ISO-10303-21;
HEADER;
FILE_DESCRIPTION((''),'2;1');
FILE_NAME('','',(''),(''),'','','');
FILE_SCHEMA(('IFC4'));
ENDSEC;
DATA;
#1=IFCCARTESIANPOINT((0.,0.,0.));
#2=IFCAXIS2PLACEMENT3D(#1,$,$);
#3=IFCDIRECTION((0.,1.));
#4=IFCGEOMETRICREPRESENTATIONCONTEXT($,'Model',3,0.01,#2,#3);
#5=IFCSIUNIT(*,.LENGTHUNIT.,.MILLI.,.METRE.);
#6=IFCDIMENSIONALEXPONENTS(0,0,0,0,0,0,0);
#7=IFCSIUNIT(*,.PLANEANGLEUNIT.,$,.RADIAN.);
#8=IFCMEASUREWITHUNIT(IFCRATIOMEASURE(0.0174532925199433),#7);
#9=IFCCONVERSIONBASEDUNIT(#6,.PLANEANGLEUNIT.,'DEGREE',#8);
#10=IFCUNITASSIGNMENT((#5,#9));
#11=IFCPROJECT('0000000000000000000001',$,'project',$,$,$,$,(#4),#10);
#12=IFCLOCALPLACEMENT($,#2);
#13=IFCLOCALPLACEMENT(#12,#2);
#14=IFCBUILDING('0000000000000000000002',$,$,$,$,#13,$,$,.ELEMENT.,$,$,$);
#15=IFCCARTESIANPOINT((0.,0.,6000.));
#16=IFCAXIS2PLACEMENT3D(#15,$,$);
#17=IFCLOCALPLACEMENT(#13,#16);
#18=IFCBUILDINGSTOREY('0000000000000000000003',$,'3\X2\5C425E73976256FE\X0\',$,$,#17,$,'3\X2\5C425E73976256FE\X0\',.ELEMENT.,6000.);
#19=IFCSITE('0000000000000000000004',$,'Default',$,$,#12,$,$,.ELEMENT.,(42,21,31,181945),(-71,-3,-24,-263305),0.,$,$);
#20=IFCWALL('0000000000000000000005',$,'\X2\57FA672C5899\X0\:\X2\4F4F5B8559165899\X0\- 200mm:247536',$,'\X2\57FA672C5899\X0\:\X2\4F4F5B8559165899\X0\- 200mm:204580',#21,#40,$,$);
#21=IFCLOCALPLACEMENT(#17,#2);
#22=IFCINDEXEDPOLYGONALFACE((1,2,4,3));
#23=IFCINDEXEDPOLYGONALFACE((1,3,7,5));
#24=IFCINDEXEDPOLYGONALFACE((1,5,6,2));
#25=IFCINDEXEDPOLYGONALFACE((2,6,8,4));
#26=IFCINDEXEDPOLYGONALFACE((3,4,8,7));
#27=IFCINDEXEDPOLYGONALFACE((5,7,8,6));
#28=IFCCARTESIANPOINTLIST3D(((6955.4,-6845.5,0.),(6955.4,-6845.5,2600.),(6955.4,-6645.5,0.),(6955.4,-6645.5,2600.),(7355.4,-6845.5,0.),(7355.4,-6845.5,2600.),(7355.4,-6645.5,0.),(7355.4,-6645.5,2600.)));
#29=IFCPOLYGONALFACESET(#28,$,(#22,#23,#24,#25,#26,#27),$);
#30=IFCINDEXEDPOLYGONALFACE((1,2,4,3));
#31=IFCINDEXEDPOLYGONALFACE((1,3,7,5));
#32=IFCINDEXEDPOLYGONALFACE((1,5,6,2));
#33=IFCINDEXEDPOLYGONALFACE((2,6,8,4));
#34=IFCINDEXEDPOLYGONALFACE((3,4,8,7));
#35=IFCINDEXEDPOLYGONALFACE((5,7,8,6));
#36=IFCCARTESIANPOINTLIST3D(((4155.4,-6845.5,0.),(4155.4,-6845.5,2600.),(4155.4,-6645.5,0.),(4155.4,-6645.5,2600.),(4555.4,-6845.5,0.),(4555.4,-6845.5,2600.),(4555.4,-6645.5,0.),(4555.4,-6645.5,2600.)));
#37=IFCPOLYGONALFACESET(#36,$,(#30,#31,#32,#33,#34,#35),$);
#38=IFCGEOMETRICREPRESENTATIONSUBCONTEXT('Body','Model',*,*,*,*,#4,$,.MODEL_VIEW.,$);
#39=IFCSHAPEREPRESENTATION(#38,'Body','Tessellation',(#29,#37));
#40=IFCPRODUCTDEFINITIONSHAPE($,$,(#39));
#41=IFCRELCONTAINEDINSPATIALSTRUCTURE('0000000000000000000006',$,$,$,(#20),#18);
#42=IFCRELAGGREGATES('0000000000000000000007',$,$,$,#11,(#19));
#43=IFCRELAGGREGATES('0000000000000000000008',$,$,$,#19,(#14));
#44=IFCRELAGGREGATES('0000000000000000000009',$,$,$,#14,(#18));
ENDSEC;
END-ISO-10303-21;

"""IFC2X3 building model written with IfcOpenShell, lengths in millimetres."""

from ifc_helpers import new_model, entity, si_unit, converted_unit, direction, frame, frame_2d, origin, place, context, subcontext, project, spatial, rectangle, extrude, element, save


model = new_model("IFC2X3")

# Units and contexts
model_context = context("Model", 3, precision=0.01, world=origin(), true_north=direction((0.0, 1.0)))
body_context = subcontext(model_context, "Body", "Model", "MODEL_VIEW")
ifc_project = project(units=[si_unit("LENGTHUNIT", "METRE", prefix="MILLI"), converted_unit("PLANEANGLEUNIT", "DEGREE", entity("IfcRatioMeasure", 0.0174532925199433), si_unit("PLANEANGLEUNIT", "RADIAN"), dimensions=[0, 0, 0, 0, 0, 0, 0])], contexts=[model_context])

# Site, building, storey
site_placement = place(None, origin())
site = spatial("IfcSite", under=ifc_project, at=site_placement, Name="Default", CompositionType="ELEMENT", RefLatitude=(42, 21, 31, 181945), RefLongitude=(-71, -3, -24, -263305), RefElevation=0.0)
building_placement = place(site_placement, origin())
building = spatial("IfcBuilding", under=site, at=building_placement, CompositionType="ELEMENT")
storey_placement = place(building_placement, frame((0.0, 0.0, 6000.0)))
storey = spatial("IfcBuildingStorey", under=building, at=storey_placement, Name="3层平面图", LongName="3层平面图", CompositionType="ELEMENT", Elevation=6000.0)

# Wall, opening
wall_placement = place(storey_placement, frame((7355.4, -6745.5, 0.0), z_axis=(0.0, 0.0, 1.0), x_axis=(-1.0, 0.0, 0.0)))
wall = element("IfcWall", 1, at=wall_placement, inside=storey, Name="基本墙:住宅外墙- 200mm:247536", ObjectType="基本墙:住宅外墙- 200mm:204580", context=body_context, shape_type="SweptSolid", body=[
    extrude(rectangle(XDim=400.0, YDim=200.0, at=frame_2d((0.0, 0.0), x_axis=(1.0, 0.0))), frame((200.0, 0.0, 0.0), z_axis=(0.0, 0.0, 1.0), x_axis=(-1.0, 0.0, 0.0)), (0.0, 0.0, 1.0), 2600.0),
    extrude(rectangle(XDim=400.0, YDim=200.0, at=frame_2d((0.0, 0.0), x_axis=(1.0, 0.0))), frame((3000.0, 0.0, 0.0)), (0.0, 0.0, 1.0), 2600.0),
])
opening_placement = place(wall_placement, frame((400.0, -100.0, 0.0)))
element("IfcOpeningElement", 2, at=opening_placement, cuts=wall, ObjectType="Opening", context=body_context, shape_type="SweptSolid", body=[
    extrude(rectangle(XDim=2600.0, YDim=2400.0, at=frame_2d((1300.0, 1200.0), x_axis=(1.0, 0.0))), frame((0.0, 0.0, 0.0), z_axis=(0.0, 1.0, 0.0), x_axis=(0.0, 0.0, 1.0)), (0.0, 0.0, 1.0), 200.0),
])

save(model, "model.ifc")
